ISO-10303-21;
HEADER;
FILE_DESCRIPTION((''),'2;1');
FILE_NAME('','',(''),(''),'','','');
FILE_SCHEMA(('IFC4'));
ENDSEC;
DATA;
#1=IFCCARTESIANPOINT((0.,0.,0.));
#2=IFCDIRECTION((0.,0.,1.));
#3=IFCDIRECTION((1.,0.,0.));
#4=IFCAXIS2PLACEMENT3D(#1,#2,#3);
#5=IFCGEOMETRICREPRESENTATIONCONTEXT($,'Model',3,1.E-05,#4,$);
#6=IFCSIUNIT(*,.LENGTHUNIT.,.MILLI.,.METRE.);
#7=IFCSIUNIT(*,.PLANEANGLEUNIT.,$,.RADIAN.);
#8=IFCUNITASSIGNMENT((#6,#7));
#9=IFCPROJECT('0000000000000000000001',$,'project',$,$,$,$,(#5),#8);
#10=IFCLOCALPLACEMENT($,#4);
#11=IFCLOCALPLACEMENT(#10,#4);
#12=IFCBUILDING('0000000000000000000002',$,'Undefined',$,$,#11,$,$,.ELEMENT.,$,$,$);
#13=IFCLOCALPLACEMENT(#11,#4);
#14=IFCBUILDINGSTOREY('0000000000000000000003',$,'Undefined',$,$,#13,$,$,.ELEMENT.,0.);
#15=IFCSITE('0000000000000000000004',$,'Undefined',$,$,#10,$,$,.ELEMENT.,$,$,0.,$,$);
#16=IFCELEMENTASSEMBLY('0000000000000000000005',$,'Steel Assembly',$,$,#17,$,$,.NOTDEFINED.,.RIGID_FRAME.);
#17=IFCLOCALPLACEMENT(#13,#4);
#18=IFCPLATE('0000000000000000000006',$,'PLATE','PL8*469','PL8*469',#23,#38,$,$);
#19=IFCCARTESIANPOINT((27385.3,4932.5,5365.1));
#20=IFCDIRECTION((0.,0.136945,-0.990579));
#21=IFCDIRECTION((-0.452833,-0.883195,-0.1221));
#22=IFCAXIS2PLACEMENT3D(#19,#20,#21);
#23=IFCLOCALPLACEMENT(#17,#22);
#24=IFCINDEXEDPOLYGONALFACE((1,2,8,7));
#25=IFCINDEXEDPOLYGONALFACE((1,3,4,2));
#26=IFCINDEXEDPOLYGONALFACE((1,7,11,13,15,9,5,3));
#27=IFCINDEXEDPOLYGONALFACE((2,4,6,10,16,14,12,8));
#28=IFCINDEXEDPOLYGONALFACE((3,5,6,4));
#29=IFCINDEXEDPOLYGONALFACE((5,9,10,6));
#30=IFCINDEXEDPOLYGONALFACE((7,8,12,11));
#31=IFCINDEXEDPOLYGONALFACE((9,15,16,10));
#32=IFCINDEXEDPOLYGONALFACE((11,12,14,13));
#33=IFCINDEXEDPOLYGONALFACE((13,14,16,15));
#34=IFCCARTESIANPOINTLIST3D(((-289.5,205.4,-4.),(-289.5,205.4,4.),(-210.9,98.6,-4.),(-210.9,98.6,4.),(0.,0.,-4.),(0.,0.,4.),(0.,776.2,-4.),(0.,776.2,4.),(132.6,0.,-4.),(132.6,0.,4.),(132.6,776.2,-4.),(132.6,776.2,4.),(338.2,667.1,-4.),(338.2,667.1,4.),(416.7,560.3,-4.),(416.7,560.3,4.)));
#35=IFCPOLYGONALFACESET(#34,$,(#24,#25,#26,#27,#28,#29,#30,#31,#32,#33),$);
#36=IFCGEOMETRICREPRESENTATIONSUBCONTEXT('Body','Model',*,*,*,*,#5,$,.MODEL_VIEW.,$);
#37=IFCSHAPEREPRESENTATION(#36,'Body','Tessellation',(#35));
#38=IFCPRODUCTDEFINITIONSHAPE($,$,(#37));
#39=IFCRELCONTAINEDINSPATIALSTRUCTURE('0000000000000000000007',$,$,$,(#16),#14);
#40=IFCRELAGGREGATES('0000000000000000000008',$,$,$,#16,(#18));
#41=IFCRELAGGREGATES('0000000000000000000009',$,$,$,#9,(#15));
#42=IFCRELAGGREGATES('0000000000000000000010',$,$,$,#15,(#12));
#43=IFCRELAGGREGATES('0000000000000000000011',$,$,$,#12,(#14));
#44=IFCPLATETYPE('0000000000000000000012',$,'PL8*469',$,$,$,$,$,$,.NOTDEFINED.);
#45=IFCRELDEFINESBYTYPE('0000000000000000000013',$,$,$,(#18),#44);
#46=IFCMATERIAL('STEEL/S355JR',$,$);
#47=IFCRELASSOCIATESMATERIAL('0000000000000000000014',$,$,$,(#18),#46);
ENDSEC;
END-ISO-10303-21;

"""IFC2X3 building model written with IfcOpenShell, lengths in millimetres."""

from ifc_helpers import new_model, si_unit, frame, origin_with_axes, place, context, subcontext, project, spatial, polyline, outline, extrude, material, type_object, element, aggregate, save


model = new_model("IFC2X3")

# Units and contexts
model_context = context("Model", 3, precision=1e-05, world=origin_with_axes())
body_context = subcontext(model_context, "Body", "Model", "MODEL_VIEW")
ifc_project = project(units=[si_unit("LENGTHUNIT", "METRE", prefix="MILLI"), si_unit("PLANEANGLEUNIT", "RADIAN")], contexts=[model_context])

# Site, building, storey
site_placement = place(None, origin_with_axes())
site = spatial("IfcSite", under=ifc_project, at=site_placement, Name="Undefined", CompositionType="ELEMENT", RefElevation=0.0)
building_placement = place(site_placement, origin_with_axes())
building = spatial("IfcBuilding", under=site, at=building_placement, Name="Undefined", CompositionType="ELEMENT")
storey_placement = place(building_placement, origin_with_axes())
storey = spatial("IfcBuildingStorey", under=building, at=storey_placement, Name="Undefined", CompositionType="ELEMENT", Elevation=0.0)

# Shared definitions
ifc_material_1 = material(Name="STEEL/S355JR")

# Element assembly, plate
assembly_1_placement = place(storey_placement, origin_with_axes())
assembly_1 = element("IfcElementAssembly", 1, at=assembly_1_placement, inside=storey, Name="Steel Assembly", AssemblyPlace="NOTDEFINED", PredefinedType="RIGID_FRAME")
plate_type_1 = type_object("IfcPlateType", Name="PL8*469", PredefinedType="NOTDEFINED")
plate_1_placement = place(assembly_1_placement, frame((27385.3, 4932.5, 5365.1), z_axis=(0.0, 0.136945, -0.990579), x_axis=(-0.452833, -0.883195, -0.1221)))
plate_1 = element("IfcPlate", 2, at=plate_1_placement, type_object=plate_type_1, material=ifc_material_1, Name="PLATE", Description="PL8*469", ObjectType="PL8*469", context=body_context, shape_type="SweptSolid", body=[
    extrude(outline(polyline([(0.0, 0.0), (132.6, 0.0), (416.7, 560.3), (338.2, 667.1), (132.6, 776.2), (0.0, 776.2), (-289.5, 205.4), (-210.9, 98.6), (0.0, 0.0)])), frame((0.0, 0.0, -4.0), z_axis=(0.0, 0.0, 1.0), x_axis=(1.0, 0.0, 0.0)), (0.0, 0.0, 1.0), 8.0),
])
aggregate(assembly_1, [plate_1])

save(model, "model.ifc")
